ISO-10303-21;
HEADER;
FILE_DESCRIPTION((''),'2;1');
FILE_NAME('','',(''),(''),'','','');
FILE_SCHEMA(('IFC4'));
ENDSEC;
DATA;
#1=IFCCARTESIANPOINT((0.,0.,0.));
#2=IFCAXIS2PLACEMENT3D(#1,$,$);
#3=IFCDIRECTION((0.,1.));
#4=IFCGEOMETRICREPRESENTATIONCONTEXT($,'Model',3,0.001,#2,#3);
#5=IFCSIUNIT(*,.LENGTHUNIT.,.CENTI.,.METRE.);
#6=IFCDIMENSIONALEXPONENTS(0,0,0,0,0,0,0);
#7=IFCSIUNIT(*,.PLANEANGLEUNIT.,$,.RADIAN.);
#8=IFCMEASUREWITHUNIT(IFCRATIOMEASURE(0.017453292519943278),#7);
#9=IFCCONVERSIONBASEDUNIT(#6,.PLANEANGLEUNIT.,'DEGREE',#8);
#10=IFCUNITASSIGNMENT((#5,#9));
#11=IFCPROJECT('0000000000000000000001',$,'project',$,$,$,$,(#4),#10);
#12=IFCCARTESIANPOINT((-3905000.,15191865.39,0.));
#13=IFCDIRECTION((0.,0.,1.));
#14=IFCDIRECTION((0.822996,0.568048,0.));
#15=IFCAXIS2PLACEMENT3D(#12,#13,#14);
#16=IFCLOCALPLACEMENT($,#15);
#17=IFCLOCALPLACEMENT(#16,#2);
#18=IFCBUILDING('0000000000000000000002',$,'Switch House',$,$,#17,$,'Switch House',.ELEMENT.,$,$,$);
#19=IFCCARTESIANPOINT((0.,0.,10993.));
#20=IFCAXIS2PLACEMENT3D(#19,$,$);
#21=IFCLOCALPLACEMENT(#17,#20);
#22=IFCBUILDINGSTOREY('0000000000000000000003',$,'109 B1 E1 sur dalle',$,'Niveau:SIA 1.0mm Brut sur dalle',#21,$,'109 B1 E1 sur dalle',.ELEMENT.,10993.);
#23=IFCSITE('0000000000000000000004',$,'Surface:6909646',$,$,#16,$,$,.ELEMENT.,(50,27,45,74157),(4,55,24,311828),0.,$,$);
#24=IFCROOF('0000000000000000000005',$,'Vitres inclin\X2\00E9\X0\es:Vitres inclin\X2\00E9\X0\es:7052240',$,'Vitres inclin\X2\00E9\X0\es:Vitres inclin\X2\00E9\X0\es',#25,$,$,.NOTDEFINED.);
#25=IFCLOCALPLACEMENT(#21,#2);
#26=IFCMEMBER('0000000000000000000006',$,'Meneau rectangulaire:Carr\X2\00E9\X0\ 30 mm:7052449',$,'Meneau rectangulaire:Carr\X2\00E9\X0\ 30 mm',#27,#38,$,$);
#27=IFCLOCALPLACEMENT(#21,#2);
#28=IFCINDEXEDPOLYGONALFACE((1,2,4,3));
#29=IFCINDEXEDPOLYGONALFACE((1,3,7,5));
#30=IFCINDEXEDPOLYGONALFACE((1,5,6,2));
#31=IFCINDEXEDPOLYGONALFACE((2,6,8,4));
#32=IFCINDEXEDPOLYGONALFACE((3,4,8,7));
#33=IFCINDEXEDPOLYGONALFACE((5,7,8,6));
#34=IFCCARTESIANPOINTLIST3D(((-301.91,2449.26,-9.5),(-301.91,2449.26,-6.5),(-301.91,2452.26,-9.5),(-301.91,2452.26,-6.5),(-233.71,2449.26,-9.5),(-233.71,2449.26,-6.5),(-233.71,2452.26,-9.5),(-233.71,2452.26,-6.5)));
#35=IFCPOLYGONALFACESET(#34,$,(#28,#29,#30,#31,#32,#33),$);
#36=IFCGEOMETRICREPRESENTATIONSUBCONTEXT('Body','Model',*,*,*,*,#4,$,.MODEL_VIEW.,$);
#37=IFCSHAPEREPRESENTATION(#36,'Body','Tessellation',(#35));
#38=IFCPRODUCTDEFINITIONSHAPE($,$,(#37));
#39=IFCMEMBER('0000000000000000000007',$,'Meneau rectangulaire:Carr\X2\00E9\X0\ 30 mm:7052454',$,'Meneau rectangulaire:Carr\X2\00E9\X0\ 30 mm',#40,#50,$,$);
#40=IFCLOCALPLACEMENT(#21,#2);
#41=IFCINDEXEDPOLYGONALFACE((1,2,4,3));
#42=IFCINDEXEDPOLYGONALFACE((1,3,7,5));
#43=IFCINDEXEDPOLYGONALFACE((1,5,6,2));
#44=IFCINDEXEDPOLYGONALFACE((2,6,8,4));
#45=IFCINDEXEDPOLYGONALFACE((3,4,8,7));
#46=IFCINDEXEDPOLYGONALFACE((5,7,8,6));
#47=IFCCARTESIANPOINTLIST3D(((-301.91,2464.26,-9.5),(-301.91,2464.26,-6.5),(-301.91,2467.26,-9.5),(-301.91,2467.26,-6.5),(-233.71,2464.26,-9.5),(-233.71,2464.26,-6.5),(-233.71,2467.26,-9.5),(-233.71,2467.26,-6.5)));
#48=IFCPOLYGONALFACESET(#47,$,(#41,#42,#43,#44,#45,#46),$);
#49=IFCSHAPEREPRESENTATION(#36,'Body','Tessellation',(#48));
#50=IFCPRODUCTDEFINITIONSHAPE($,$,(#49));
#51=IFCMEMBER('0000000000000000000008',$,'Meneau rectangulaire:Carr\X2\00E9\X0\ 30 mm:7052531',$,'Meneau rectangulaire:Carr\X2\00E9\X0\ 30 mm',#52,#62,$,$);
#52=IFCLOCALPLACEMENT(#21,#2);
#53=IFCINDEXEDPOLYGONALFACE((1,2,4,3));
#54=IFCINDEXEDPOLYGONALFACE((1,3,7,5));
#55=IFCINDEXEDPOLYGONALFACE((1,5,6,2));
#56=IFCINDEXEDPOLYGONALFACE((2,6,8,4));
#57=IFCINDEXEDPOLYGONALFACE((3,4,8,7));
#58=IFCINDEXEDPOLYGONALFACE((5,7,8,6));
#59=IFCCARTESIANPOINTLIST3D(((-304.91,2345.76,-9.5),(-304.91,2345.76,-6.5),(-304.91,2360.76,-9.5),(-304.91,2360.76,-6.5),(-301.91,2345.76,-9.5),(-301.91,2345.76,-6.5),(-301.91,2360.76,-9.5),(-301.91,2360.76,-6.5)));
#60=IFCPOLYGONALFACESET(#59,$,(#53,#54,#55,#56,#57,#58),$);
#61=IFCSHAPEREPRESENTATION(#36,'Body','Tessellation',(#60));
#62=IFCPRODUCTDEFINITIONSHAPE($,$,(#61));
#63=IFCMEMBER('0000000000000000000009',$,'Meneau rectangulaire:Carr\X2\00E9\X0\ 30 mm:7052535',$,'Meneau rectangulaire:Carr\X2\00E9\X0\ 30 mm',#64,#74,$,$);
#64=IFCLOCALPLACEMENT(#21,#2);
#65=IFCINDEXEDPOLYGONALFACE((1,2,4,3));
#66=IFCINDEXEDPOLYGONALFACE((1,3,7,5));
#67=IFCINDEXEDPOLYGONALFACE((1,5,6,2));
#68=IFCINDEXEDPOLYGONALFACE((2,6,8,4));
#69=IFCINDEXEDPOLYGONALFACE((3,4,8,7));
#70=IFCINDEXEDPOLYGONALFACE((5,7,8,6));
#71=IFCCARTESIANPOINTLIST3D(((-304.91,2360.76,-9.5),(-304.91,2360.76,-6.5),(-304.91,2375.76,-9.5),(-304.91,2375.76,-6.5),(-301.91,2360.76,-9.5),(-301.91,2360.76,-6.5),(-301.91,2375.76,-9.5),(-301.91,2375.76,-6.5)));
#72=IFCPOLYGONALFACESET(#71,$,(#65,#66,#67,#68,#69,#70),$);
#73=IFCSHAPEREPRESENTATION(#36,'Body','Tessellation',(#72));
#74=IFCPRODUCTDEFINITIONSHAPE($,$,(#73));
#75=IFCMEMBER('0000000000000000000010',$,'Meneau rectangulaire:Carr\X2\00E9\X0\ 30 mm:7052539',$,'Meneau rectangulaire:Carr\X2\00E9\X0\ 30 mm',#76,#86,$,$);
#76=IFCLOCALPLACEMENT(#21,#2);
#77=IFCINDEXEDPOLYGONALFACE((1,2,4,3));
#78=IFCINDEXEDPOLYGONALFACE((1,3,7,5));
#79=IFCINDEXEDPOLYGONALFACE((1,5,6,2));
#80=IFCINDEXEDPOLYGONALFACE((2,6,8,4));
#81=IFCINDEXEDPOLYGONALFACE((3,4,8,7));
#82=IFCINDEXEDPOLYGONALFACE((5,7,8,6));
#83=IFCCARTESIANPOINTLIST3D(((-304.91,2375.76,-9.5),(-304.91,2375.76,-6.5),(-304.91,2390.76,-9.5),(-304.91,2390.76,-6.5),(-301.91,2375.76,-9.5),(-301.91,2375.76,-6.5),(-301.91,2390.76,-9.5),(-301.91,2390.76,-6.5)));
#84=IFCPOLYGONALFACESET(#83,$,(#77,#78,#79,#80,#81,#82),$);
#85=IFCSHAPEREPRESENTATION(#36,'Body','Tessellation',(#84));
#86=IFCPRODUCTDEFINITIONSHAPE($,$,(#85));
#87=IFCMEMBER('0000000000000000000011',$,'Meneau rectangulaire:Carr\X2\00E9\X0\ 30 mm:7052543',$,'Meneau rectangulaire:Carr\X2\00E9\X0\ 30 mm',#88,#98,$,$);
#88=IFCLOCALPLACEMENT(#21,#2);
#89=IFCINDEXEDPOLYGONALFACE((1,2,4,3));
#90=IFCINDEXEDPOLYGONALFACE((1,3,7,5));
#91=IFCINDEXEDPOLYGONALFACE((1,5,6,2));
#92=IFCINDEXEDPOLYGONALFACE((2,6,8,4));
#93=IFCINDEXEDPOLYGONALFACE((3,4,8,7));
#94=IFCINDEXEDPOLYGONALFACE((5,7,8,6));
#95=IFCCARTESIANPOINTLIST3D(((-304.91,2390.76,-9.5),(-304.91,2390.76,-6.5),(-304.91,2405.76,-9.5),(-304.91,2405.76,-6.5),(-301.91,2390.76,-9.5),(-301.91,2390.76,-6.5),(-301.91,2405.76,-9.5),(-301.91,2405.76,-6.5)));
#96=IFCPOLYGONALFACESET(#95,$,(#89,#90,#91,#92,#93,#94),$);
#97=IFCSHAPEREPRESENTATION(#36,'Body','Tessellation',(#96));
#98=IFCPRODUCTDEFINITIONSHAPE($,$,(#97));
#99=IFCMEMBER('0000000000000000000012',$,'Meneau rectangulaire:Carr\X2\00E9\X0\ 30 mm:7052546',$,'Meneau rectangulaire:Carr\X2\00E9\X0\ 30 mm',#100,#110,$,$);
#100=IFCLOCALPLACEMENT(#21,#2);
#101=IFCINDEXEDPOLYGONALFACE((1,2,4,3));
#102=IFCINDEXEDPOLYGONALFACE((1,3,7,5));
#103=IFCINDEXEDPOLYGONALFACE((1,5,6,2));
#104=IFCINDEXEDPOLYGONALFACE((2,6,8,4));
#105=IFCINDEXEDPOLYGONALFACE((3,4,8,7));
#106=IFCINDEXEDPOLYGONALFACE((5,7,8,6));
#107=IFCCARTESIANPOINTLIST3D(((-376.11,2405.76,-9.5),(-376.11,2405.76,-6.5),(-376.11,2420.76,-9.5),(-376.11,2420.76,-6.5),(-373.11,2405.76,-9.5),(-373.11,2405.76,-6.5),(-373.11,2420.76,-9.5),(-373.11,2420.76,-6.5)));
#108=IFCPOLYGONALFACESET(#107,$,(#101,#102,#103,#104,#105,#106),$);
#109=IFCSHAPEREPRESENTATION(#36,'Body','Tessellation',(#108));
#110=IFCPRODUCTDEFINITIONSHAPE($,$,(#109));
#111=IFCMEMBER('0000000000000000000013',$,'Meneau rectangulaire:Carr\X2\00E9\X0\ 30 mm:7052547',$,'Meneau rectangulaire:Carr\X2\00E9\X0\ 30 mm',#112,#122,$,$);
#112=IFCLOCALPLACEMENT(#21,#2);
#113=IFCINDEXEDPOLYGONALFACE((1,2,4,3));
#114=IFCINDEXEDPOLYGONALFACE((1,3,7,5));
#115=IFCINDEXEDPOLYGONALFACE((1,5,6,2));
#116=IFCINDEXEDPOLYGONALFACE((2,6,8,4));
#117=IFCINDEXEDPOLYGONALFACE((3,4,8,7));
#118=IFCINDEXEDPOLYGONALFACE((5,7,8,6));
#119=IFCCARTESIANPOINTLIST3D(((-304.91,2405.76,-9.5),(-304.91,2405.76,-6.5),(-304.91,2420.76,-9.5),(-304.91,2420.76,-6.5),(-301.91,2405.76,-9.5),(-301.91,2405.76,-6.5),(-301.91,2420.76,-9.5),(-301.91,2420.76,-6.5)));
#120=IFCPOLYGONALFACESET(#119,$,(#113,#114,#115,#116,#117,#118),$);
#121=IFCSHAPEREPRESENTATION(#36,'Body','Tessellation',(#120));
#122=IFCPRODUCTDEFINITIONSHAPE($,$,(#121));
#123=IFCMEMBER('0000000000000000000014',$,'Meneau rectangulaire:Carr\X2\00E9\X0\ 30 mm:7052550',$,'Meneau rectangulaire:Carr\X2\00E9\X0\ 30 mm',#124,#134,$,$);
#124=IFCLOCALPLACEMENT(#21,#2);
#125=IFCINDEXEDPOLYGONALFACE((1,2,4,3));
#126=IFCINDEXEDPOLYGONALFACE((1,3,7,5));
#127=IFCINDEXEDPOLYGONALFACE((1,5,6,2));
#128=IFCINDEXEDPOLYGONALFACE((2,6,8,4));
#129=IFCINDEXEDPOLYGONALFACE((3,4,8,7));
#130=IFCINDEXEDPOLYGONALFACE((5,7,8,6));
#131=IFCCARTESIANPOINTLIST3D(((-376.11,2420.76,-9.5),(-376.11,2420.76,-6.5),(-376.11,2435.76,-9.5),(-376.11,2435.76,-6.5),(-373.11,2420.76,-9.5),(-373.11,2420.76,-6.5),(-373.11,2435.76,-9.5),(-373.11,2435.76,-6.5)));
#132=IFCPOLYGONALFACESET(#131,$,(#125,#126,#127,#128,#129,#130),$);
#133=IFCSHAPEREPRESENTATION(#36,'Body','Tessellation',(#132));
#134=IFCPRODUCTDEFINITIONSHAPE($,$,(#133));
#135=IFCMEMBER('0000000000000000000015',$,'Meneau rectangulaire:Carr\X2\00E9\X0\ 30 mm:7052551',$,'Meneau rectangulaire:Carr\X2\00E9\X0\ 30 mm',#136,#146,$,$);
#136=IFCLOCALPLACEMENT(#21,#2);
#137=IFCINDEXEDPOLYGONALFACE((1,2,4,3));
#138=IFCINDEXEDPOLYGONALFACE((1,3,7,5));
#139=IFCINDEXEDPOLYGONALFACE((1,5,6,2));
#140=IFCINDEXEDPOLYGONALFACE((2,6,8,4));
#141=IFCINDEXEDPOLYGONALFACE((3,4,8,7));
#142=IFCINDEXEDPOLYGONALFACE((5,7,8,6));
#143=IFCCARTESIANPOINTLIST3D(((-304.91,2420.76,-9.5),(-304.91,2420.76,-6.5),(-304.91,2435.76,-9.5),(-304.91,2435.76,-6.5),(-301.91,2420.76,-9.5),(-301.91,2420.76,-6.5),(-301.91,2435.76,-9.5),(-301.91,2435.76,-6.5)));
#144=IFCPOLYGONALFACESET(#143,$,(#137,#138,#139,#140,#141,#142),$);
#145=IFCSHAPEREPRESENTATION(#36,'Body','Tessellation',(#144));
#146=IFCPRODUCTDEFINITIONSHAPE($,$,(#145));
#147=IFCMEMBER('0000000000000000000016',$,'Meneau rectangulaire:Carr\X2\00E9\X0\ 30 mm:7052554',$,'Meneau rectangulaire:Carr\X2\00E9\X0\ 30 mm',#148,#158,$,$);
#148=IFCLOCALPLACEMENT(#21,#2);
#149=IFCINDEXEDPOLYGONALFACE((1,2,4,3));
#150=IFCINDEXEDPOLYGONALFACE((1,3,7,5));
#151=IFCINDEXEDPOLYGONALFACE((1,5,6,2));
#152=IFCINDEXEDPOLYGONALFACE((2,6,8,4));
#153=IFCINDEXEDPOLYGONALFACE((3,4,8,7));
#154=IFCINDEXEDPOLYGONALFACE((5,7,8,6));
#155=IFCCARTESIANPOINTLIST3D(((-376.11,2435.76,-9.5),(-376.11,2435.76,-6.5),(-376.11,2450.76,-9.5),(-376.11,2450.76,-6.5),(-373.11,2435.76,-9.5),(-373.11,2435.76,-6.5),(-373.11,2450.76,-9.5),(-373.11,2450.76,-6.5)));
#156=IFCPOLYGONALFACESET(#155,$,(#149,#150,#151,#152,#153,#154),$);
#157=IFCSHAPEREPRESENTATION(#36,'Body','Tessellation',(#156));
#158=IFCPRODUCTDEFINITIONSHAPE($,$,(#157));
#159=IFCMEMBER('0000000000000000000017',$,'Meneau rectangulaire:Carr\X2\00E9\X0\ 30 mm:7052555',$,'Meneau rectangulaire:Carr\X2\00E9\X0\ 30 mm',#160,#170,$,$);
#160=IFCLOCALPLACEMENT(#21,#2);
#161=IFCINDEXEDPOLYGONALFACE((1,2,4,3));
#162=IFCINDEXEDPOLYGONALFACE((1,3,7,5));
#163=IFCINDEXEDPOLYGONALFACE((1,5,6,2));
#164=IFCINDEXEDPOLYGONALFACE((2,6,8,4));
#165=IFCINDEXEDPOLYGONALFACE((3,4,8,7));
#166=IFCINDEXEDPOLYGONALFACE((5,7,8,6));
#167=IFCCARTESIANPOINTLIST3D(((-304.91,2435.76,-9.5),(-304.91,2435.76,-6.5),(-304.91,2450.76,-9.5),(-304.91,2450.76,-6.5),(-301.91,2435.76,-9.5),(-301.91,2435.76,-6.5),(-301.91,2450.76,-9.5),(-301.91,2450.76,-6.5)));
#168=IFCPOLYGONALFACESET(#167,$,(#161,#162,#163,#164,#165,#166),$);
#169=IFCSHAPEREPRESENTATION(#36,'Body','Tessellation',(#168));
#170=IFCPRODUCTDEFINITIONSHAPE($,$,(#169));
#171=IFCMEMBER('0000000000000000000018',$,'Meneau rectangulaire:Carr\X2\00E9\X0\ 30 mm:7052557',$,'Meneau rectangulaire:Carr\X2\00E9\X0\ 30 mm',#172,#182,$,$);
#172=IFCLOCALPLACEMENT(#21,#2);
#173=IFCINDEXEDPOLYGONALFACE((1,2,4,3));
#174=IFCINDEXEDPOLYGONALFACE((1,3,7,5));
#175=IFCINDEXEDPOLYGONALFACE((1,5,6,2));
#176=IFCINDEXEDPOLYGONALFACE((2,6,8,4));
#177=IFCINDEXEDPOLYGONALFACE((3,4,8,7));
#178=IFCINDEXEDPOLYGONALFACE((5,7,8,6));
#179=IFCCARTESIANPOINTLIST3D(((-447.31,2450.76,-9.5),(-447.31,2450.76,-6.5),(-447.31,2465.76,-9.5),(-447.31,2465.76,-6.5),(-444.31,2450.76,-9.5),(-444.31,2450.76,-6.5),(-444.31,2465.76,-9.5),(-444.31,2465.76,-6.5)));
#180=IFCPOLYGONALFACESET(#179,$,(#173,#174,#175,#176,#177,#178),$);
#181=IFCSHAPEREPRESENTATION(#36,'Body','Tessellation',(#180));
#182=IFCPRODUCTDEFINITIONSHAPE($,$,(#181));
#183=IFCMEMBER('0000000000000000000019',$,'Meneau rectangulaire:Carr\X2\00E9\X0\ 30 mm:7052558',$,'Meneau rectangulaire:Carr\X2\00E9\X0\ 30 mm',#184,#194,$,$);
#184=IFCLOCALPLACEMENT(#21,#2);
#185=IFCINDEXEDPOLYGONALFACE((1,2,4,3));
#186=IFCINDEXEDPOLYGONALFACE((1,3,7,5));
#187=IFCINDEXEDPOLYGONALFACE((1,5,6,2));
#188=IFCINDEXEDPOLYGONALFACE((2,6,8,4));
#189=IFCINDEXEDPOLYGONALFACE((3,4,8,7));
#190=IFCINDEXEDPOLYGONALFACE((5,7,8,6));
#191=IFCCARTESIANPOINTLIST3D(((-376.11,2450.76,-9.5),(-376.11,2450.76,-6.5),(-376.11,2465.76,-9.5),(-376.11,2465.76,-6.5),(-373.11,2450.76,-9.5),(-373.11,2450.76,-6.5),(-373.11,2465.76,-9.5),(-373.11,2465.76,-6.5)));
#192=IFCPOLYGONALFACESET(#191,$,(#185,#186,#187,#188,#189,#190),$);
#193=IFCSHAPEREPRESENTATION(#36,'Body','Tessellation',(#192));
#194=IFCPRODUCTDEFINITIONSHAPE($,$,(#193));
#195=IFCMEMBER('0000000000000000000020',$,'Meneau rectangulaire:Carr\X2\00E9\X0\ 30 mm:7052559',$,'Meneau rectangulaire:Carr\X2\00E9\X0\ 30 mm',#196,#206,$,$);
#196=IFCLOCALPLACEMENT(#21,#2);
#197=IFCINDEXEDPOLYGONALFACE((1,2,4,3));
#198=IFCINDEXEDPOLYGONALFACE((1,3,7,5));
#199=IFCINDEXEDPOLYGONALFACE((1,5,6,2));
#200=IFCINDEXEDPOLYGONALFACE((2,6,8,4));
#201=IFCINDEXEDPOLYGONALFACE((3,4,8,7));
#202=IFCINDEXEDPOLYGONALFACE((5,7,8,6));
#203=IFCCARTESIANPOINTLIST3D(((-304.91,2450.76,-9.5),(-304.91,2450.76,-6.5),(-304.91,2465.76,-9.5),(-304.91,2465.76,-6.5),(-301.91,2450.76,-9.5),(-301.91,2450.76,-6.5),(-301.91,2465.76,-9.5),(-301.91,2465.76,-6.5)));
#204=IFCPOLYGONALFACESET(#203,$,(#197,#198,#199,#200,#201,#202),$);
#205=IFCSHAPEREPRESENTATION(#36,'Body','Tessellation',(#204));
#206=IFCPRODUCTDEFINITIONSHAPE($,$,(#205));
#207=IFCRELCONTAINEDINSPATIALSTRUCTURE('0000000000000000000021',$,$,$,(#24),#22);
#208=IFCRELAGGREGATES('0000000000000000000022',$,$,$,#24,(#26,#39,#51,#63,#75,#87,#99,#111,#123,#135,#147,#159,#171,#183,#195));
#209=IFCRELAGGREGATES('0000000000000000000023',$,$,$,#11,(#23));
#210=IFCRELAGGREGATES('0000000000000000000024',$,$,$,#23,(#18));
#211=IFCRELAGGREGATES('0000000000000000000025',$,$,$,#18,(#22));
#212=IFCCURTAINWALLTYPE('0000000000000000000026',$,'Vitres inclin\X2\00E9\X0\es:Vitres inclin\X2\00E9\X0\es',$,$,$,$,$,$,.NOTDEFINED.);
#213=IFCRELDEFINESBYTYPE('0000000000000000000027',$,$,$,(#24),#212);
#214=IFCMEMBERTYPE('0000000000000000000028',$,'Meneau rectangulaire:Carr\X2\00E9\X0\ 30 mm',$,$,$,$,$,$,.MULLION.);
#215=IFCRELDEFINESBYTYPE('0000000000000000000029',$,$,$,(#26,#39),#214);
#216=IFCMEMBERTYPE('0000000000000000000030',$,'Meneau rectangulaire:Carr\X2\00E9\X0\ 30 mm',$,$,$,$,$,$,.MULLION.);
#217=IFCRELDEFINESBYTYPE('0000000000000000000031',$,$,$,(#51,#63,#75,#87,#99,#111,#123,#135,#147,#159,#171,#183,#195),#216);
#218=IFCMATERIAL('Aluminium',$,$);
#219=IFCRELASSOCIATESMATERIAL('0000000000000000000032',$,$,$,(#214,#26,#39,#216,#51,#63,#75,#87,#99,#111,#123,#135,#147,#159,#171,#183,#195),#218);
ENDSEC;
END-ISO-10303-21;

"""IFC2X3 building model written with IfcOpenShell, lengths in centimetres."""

from ifc_helpers import new_model, entity, si_unit, converted_unit, direction, frame, origin, origin_2d_with_axis, place, context, subcontext, project, spatial, rectangle, extrude, source, transform, mapped, material, type_object, type_shapes, element, aggregate, save


model = new_model("IFC2X3")

# Units and contexts
model_context = context("Model", 3, precision=0.001, world=origin(), true_north=direction((0.0, 1.0)))
body_context = subcontext(model_context, "Body", "Model", "MODEL_VIEW")
ifc_project = project(units=[si_unit("LENGTHUNIT", "METRE", prefix="CENTI"), converted_unit("PLANEANGLEUNIT", "DEGREE", entity("IfcRatioMeasure", 0.017453292519943278), si_unit("PLANEANGLEUNIT", "RADIAN"), dimensions=[0, 0, 0, 0, 0, 0, 0])], contexts=[model_context])

# Site, building, storey
site_placement = place(None, frame((-3905000.0, 15191865.39, 0.0), z_axis=(0.0, 0.0, 1.0), x_axis=(0.822996, 0.568048, 0.0)))
site = spatial("IfcSite", under=ifc_project, at=site_placement, Name="Surface:6909646", CompositionType="ELEMENT", RefLatitude=(50, 27, 45, 74157), RefLongitude=(4, 55, 24, 311828), RefElevation=0.0)
building_placement = place(site_placement, origin())
building = spatial("IfcBuilding", under=site, at=building_placement, Name="Switch House", LongName="Switch House", CompositionType="ELEMENT")
storey_placement = place(building_placement, frame((0.0, 0.0, 10993.0)))
storey = spatial("IfcBuildingStorey", under=building, at=storey_placement, Name="109 B1 E1 sur dalle", ObjectType="Niveau:SIA 1.0mm Brut sur dalle", LongName="109 B1 E1 sur dalle", CompositionType="ELEMENT", Elevation=10993.0)

# Roof, members
curtain_wall_type = type_object("IfcCurtainWallType", Name="Vitres inclinées:Vitres inclinées", PredefinedType="NOTDEFINED")
roof_placement = place(storey_placement, frame((0.0, 0.0, -10993.0)))
roof = element("IfcRoof", 1, at=roof_placement, inside=storey, type_object=curtain_wall_type, Name="Vitres inclinées:Vitres inclinées:7052240", ObjectType="Vitres inclinées:Vitres inclinées", ShapeType="NOTDEFINED")
ifc_material = material(Name="Aluminium")
member_type_1 = type_object("IfcMemberType", Name="Meneau rectangulaire:Carré 30 mm", PredefinedType="MULLION", material=ifc_material)
shared_shape_1 = source(origin(), body_context, "Body", "SweptSolid", [
    extrude(rectangle(XDim=3.0, YDim=3.0, at=origin_2d_with_axis()), frame((0.0, 0.0, -68.2), z_axis=(0.0, 0.0, 1.0), x_axis=(0.0, -1.0, 0.0)), (0.0, 0.0, 1.0), 68.2),
])
type_shapes(member_type_1, [shared_shape_1])
member_1_placement = place(roof_placement, frame((-301.91, 2450.76, 10985.0), z_axis=(-1.0, 0.0, 0.0), x_axis=(0.0, 1.0, 0.0)))
member_1 = element("IfcMember", 2, at=member_1_placement, type_object=member_type_1, material=ifc_material, Name="Meneau rectangulaire:Carré 30 mm:7052449", ObjectType="Meneau rectangulaire:Carré 30 mm", context=body_context, shape_type="MappedRepresentation", body=[
    mapped(shared_shape_1, transform((0.0, 0.0, 0.0), scale=1.0)),
])
member_2_placement = place(roof_placement, frame((-301.91, 2465.76, 10985.0), z_axis=(-1.0, 0.0, 0.0), x_axis=(0.0, 1.0, 0.0)))
member_2 = element("IfcMember", 3, at=member_2_placement, type_object=member_type_1, material=ifc_material, Name="Meneau rectangulaire:Carré 30 mm:7052454", ObjectType="Meneau rectangulaire:Carré 30 mm", context=body_context, shape_type="MappedRepresentation", body=[
    mapped(shared_shape_1, transform((0.0, 0.0, 0.0), scale=1.0)),
])
member_type_2 = type_object("IfcMemberType", Name="Meneau rectangulaire:Carré 30 mm", PredefinedType="MULLION", material=ifc_material)
shared_shape_2 = source(origin(), body_context, "Body", "SweptSolid", [
    extrude(rectangle(XDim=3.0, YDim=3.0, at=origin_2d_with_axis()), frame((0.0, 0.0, -15.0), z_axis=(0.0, 0.0, 1.0), x_axis=(0.0, -1.0, 0.0)), (0.0, 0.0, 1.0), 15.0),
])
type_shapes(member_type_2, [shared_shape_2])
member_3_placement = place(roof_placement, frame((-303.41, 2360.76, 10985.0), z_axis=(0.0, 1.0, 0.0), x_axis=(1.0, 0.0, 0.0)))
member_3 = element("IfcMember", 4, at=member_3_placement, type_object=member_type_2, material=ifc_material, Name="Meneau rectangulaire:Carré 30 mm:7052531", ObjectType="Meneau rectangulaire:Carré 30 mm", context=body_context, shape_type="MappedRepresentation", body=[
    mapped(shared_shape_2, transform((0.0, 0.0, 0.0), scale=1.0)),
])
member_4_placement = place(roof_placement, frame((-303.41, 2375.76, 10985.0), z_axis=(0.0, 1.0, 0.0), x_axis=(1.0, 0.0, 0.0)))
member_4 = element("IfcMember", 5, at=member_4_placement, type_object=member_type_2, material=ifc_material, Name="Meneau rectangulaire:Carré 30 mm:7052535", ObjectType="Meneau rectangulaire:Carré 30 mm", context=body_context, shape_type="MappedRepresentation", body=[
    mapped(shared_shape_2, transform((0.0, 0.0, 0.0), scale=1.0)),
])
member_5_placement = place(roof_placement, frame((-303.41, 2390.76, 10985.0), z_axis=(0.0, 1.0, 0.0), x_axis=(1.0, 0.0, 0.0)))
member_5 = element("IfcMember", 6, at=member_5_placement, type_object=member_type_2, material=ifc_material, Name="Meneau rectangulaire:Carré 30 mm:7052539", ObjectType="Meneau rectangulaire:Carré 30 mm", context=body_context, shape_type="MappedRepresentation", body=[
    mapped(shared_shape_2, transform((0.0, 0.0, 0.0), scale=1.0)),
])
member_6_placement = place(roof_placement, frame((-303.41, 2405.76, 10985.0), z_axis=(0.0, 1.0, 0.0), x_axis=(1.0, 0.0, 0.0)))
member_6 = element("IfcMember", 7, at=member_6_placement, type_object=member_type_2, material=ifc_material, Name="Meneau rectangulaire:Carré 30 mm:7052543", ObjectType="Meneau rectangulaire:Carré 30 mm", context=body_context, shape_type="MappedRepresentation", body=[
    mapped(shared_shape_2, transform((0.0, 0.0, 0.0), scale=1.0)),
])
member_7_placement = place(roof_placement, frame((-374.61, 2420.76, 10985.0), z_axis=(0.0, 1.0, 0.0), x_axis=(1.0, 0.0, 0.0)))
member_7 = element("IfcMember", 8, at=member_7_placement, type_object=member_type_2, material=ifc_material, Name="Meneau rectangulaire:Carré 30 mm:7052546", ObjectType="Meneau rectangulaire:Carré 30 mm", context=body_context, shape_type="MappedRepresentation", body=[
    mapped(shared_shape_2, transform((0.0, 0.0, 0.0), scale=1.0)),
])
member_8_placement = place(roof_placement, frame((-303.41, 2420.76, 10985.0), z_axis=(0.0, 1.0, 0.0), x_axis=(1.0, 0.0, 0.0)))
member_8 = element("IfcMember", 9, at=member_8_placement, type_object=member_type_2, material=ifc_material, Name="Meneau rectangulaire:Carré 30 mm:7052547", ObjectType="Meneau rectangulaire:Carré 30 mm", context=body_context, shape_type="MappedRepresentation", body=[
    mapped(shared_shape_2, transform((0.0, 0.0, 0.0), scale=1.0)),
])
member_9_placement = place(roof_placement, frame((-374.61, 2435.76, 10985.0), z_axis=(0.0, 1.0, 0.0), x_axis=(1.0, 0.0, 0.0)))
member_9 = element("IfcMember", 10, at=member_9_placement, type_object=member_type_2, material=ifc_material, Name="Meneau rectangulaire:Carré 30 mm:7052550", ObjectType="Meneau rectangulaire:Carré 30 mm", context=body_context, shape_type="MappedRepresentation", body=[
    mapped(shared_shape_2, transform((0.0, 0.0, 0.0), scale=1.0)),
])
member_10_placement = place(roof_placement, frame((-303.41, 2435.76, 10985.0), z_axis=(0.0, 1.0, 0.0), x_axis=(1.0, 0.0, 0.0)))
member_10 = element("IfcMember", 11, at=member_10_placement, type_object=member_type_2, material=ifc_material, Name="Meneau rectangulaire:Carré 30 mm:7052551", ObjectType="Meneau rectangulaire:Carré 30 mm", context=body_context, shape_type="MappedRepresentation", body=[
    mapped(shared_shape_2, transform((0.0, 0.0, 0.0), scale=1.0)),
])
member_11_placement = place(roof_placement, frame((-374.61, 2450.76, 10985.0), z_axis=(0.0, 1.0, 0.0), x_axis=(1.0, 0.0, 0.0)))
member_11 = element("IfcMember", 12, at=member_11_placement, type_object=member_type_2, material=ifc_material, Name="Meneau rectangulaire:Carré 30 mm:7052554", ObjectType="Meneau rectangulaire:Carré 30 mm", context=body_context, shape_type="MappedRepresentation", body=[
    mapped(shared_shape_2, transform((0.0, 0.0, 0.0), scale=1.0)),
])
member_12_placement = place(roof_placement, frame((-303.41, 2450.76, 10985.0), z_axis=(0.0, 1.0, 0.0), x_axis=(1.0, 0.0, 0.0)))
member_12 = element("IfcMember", 13, at=member_12_placement, type_object=member_type_2, material=ifc_material, Name="Meneau rectangulaire:Carré 30 mm:7052555", ObjectType="Meneau rectangulaire:Carré 30 mm", context=body_context, shape_type="MappedRepresentation", body=[
    mapped(shared_shape_2, transform((0.0, 0.0, 0.0), scale=1.0)),
])
member_13_placement = place(roof_placement, frame((-445.81, 2465.76, 10985.0), z_axis=(0.0, 1.0, 0.0), x_axis=(1.0, 0.0, 0.0)))
member_13 = element("IfcMember", 14, at=member_13_placement, type_object=member_type_2, material=ifc_material, Name="Meneau rectangulaire:Carré 30 mm:7052557", ObjectType="Meneau rectangulaire:Carré 30 mm", context=body_context, shape_type="MappedRepresentation", body=[
    mapped(shared_shape_2, transform((0.0, 0.0, 0.0), scale=1.0)),
])
member_14_placement = place(roof_placement, frame((-374.61, 2465.76, 10985.0), z_axis=(0.0, 1.0, 0.0), x_axis=(1.0, 0.0, 0.0)))
member_14 = element("IfcMember", 15, at=member_14_placement, type_object=member_type_2, material=ifc_material, Name="Meneau rectangulaire:Carré 30 mm:7052558", ObjectType="Meneau rectangulaire:Carré 30 mm", context=body_context, shape_type="MappedRepresentation", body=[
    mapped(shared_shape_2, transform((0.0, 0.0, 0.0), scale=1.0)),
])
member_15_placement = place(roof_placement, frame((-303.41, 2465.76, 10985.0), z_axis=(0.0, 1.0, 0.0), x_axis=(1.0, 0.0, 0.0)))
member_15 = element("IfcMember", 16, at=member_15_placement, type_object=member_type_2, material=ifc_material, Name="Meneau rectangulaire:Carré 30 mm:7052559", ObjectType="Meneau rectangulaire:Carré 30 mm", context=body_context, shape_type="MappedRepresentation", body=[
    mapped(shared_shape_2, transform((0.0, 0.0, 0.0), scale=1.0)),
])
aggregate(roof, [member_1, member_2, member_3, member_4, member_5, member_6, member_7, member_8, member_9, member_10, member_11, member_12, member_13, member_14, member_15])

save(model, "model.ifc")
